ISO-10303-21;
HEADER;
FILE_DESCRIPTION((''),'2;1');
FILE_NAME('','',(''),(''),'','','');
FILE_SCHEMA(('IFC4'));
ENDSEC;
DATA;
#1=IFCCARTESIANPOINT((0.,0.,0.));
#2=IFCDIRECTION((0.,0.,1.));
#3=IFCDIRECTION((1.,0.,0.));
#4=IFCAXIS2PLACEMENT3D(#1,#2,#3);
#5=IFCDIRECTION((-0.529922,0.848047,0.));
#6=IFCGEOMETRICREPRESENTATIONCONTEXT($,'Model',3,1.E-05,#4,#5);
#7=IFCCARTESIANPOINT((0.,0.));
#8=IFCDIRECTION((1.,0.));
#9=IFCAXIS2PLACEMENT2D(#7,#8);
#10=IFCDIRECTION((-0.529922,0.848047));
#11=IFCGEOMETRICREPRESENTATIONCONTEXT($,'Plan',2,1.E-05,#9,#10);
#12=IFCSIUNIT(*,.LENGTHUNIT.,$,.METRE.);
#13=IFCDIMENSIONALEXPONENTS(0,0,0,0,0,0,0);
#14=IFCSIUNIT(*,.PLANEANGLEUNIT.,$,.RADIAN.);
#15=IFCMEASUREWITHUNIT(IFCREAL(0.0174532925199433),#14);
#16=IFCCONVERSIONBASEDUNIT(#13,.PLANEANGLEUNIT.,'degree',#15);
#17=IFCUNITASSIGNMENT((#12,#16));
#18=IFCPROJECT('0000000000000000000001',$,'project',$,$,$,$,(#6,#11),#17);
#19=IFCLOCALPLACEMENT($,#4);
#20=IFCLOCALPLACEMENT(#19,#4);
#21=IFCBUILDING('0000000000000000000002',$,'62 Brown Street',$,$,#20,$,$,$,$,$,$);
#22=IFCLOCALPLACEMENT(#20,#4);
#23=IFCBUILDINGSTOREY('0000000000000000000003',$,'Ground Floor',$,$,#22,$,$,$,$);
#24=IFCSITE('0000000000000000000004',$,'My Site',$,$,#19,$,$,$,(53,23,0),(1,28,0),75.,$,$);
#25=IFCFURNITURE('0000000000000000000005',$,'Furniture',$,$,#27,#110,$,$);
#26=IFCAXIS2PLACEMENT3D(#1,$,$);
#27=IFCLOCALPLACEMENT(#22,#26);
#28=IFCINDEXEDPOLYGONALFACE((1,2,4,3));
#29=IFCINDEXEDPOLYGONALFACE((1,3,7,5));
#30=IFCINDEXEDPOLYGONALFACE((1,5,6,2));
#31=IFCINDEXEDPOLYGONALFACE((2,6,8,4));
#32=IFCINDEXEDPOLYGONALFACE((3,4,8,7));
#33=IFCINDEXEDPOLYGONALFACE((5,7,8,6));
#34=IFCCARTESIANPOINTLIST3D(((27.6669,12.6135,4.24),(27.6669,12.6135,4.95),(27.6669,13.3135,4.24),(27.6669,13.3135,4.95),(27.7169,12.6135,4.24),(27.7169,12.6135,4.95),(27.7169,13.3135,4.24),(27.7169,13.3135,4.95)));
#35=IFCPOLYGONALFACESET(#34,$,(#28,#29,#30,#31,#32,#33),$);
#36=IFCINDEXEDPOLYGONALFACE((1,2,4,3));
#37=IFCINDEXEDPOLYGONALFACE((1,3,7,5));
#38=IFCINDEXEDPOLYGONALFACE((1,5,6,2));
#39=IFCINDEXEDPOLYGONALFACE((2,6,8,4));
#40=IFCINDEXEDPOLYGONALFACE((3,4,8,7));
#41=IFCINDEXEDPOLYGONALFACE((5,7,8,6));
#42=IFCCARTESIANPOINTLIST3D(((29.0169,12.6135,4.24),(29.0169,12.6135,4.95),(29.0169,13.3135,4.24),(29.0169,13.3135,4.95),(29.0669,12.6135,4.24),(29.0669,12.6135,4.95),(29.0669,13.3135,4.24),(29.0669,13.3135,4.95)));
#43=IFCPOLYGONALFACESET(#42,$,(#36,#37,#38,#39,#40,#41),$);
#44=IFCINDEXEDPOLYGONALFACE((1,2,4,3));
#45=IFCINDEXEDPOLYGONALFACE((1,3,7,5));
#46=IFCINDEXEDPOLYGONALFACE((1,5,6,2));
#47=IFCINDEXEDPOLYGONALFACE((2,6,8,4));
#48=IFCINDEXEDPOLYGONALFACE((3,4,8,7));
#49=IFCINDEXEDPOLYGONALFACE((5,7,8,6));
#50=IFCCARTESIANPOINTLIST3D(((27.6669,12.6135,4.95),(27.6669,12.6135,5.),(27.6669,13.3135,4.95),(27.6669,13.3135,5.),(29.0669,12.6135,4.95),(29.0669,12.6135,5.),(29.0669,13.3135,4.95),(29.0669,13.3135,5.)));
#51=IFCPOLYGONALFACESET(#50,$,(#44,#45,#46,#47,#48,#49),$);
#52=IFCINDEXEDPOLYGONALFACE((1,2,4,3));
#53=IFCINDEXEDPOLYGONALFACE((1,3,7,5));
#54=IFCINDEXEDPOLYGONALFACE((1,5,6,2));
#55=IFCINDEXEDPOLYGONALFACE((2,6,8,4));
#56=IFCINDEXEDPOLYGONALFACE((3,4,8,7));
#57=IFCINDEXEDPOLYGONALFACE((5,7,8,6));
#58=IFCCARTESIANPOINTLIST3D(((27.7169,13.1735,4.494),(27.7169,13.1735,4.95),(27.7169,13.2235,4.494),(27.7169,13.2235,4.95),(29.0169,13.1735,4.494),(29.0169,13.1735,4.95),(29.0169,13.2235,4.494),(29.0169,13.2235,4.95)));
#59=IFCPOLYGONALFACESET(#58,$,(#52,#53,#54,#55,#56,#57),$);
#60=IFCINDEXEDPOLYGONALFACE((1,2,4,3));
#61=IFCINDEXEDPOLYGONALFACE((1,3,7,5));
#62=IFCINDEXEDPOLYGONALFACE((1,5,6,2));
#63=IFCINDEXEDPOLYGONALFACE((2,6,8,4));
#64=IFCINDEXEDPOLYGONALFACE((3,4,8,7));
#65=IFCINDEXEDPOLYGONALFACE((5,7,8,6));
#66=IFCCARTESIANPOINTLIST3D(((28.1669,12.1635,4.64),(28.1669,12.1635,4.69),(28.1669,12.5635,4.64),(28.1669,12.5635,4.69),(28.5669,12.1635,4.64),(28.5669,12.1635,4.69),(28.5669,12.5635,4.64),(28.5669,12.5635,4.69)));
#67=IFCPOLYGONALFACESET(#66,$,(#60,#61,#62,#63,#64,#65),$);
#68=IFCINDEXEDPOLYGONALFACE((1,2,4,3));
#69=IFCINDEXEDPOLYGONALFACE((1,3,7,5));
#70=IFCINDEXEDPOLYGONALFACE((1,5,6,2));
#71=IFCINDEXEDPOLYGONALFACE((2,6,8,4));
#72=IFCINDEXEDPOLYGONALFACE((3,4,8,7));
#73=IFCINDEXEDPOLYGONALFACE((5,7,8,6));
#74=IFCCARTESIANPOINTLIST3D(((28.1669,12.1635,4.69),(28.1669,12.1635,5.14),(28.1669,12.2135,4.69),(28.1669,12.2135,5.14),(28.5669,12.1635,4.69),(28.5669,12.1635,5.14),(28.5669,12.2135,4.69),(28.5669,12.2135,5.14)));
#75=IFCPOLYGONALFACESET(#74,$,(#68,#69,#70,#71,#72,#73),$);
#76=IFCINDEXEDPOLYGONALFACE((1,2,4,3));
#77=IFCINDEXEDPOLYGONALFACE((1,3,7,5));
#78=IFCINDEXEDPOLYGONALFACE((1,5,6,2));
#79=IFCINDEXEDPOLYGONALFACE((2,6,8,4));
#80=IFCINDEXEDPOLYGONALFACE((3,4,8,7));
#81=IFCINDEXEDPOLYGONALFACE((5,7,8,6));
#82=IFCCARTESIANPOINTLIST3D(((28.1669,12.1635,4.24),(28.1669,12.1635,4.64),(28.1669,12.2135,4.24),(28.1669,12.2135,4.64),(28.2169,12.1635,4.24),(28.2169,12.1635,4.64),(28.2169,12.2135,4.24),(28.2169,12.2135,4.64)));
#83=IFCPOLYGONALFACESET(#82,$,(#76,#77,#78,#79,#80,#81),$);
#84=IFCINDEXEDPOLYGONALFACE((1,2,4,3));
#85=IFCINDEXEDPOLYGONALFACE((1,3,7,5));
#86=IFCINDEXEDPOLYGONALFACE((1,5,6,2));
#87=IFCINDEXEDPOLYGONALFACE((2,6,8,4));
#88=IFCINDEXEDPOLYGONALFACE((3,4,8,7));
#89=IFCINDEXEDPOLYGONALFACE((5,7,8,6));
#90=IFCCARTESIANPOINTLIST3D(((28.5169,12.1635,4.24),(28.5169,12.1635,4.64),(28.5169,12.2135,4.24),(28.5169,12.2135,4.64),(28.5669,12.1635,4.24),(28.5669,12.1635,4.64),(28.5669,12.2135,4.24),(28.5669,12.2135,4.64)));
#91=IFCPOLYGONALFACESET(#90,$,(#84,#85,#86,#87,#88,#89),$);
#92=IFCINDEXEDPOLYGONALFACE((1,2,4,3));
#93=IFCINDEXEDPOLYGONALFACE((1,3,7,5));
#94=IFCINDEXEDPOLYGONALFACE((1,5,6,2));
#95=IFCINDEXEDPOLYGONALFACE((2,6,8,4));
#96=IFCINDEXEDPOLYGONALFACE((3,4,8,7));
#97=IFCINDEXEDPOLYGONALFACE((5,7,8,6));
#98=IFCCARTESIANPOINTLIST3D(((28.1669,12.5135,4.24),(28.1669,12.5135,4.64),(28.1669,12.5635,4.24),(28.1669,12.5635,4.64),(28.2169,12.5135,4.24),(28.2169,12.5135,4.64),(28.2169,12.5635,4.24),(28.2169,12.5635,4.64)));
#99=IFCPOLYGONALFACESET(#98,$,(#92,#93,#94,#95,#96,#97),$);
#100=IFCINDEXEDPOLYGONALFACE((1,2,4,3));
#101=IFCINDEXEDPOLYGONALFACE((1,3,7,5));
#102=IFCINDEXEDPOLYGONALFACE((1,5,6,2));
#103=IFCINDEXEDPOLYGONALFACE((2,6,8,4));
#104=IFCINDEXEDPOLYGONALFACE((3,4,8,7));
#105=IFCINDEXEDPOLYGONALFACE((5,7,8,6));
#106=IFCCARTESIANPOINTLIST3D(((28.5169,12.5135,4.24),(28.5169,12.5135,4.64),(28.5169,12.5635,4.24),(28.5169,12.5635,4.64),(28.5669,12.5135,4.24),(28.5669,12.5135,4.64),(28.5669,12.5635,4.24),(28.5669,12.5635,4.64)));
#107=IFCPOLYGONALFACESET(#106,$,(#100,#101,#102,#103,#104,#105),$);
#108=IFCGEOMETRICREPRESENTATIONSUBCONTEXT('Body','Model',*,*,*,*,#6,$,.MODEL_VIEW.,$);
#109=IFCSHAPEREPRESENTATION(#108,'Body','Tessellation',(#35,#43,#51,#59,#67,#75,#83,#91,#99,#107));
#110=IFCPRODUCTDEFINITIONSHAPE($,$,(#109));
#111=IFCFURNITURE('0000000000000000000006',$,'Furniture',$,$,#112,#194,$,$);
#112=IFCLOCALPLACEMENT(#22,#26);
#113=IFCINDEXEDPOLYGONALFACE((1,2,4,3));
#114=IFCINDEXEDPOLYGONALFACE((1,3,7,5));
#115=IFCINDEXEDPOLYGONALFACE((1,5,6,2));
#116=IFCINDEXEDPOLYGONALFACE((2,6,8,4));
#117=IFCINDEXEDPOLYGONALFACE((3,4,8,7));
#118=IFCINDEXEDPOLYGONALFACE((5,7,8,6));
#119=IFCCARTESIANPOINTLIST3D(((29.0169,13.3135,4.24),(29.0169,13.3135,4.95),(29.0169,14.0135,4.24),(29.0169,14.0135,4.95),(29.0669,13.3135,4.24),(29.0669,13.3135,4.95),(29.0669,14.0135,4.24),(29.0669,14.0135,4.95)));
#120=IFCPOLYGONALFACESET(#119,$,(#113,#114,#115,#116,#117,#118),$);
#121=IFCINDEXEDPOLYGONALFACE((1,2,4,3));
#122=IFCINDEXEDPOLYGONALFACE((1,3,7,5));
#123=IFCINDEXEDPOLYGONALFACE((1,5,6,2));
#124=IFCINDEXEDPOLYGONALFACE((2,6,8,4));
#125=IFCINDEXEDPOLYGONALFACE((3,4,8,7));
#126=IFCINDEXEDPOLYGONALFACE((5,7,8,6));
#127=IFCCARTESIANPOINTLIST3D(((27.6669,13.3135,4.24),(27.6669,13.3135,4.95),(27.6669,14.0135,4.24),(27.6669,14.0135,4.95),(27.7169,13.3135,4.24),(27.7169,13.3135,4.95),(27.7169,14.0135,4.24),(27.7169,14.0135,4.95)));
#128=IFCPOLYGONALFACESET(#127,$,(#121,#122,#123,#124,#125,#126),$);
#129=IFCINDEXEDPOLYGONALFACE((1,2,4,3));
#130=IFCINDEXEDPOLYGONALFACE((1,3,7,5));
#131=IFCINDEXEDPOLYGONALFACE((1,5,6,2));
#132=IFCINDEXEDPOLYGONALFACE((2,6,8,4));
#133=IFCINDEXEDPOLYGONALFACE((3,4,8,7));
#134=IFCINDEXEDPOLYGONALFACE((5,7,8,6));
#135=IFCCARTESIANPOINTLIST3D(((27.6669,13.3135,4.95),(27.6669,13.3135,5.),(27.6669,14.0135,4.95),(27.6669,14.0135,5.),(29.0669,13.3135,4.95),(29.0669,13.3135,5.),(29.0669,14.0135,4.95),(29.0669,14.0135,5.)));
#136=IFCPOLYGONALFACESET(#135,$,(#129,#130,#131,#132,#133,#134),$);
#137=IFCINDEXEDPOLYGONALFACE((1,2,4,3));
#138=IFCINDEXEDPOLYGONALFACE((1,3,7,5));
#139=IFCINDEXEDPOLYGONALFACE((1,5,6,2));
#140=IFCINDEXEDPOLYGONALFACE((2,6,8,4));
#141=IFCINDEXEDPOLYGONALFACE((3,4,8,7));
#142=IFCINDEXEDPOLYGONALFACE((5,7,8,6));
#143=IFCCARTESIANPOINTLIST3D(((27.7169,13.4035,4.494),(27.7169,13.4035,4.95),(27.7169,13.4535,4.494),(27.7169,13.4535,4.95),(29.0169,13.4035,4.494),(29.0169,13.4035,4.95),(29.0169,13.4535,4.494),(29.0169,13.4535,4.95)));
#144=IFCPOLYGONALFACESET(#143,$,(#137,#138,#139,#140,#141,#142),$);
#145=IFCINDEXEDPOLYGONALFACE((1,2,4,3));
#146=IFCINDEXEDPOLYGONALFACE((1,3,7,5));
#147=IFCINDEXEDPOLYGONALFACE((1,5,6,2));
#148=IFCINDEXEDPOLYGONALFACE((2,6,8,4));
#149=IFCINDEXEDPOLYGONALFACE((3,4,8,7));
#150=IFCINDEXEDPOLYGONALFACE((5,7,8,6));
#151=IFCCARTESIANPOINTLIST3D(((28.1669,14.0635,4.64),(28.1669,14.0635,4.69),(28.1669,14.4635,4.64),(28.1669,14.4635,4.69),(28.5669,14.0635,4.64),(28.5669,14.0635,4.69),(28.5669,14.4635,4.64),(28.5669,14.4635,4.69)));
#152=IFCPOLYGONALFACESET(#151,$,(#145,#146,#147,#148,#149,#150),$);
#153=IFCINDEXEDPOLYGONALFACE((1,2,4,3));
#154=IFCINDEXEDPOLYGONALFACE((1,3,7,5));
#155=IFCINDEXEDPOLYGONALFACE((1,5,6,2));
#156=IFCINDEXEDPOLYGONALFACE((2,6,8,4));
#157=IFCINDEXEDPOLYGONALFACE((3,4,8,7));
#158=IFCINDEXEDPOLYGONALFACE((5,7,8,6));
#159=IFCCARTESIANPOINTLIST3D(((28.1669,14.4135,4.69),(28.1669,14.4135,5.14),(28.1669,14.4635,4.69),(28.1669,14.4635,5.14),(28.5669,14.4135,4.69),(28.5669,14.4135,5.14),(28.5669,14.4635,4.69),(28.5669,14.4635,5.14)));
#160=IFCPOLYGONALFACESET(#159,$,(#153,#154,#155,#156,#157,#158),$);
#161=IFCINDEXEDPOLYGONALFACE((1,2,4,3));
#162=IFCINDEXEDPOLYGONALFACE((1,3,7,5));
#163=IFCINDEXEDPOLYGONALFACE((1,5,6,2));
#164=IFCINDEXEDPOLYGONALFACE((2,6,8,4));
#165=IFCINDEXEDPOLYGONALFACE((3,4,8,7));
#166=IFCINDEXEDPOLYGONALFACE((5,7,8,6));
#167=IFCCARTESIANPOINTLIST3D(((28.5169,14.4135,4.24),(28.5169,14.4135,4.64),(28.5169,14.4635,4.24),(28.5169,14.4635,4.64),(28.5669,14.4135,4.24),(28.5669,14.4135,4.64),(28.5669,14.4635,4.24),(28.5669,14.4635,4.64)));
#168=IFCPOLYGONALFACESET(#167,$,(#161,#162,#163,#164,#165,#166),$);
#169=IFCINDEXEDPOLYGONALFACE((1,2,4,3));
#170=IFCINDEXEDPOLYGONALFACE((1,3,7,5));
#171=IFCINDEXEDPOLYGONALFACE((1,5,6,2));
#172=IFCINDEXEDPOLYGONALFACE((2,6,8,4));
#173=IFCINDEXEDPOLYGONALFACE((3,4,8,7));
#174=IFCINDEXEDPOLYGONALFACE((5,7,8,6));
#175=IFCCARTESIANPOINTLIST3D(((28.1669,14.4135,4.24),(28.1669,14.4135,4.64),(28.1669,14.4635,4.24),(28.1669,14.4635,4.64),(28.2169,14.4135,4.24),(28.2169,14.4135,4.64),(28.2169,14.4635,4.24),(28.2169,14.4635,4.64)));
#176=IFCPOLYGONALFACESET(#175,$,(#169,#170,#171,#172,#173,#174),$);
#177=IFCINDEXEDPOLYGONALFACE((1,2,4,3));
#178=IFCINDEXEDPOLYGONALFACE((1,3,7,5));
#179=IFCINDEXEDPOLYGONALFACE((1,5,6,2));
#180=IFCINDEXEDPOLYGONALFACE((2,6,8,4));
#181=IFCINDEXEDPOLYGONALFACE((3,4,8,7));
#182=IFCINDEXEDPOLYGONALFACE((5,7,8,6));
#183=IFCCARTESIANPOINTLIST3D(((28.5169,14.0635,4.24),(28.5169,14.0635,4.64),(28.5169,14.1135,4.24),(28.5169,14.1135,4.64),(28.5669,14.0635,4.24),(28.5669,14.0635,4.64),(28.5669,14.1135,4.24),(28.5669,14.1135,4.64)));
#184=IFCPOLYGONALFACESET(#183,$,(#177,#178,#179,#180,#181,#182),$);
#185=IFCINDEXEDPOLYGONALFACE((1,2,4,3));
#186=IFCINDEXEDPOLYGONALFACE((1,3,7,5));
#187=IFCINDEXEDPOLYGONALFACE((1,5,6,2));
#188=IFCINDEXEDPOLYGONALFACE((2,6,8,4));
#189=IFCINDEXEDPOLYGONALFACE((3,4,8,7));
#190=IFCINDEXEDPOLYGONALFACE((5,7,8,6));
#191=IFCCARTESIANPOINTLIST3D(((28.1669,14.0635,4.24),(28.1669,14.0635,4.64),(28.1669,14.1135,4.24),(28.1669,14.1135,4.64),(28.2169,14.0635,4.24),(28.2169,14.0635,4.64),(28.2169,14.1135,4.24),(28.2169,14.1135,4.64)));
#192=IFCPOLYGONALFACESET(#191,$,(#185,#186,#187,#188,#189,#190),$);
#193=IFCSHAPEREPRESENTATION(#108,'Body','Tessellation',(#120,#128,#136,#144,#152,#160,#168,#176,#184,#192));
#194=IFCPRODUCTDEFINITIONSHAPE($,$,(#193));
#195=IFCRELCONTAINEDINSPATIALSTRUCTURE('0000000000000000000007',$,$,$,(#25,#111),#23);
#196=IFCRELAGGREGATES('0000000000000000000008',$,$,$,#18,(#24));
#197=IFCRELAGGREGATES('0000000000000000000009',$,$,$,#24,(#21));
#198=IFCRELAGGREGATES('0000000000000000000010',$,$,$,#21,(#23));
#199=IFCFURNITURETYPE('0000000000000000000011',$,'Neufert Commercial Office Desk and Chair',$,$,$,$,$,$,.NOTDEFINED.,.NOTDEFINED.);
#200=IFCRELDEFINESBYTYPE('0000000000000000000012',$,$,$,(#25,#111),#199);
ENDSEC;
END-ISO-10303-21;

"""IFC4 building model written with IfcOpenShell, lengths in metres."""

from ifc_helpers import new_model, entity, si_unit, converted_unit, direction, frame, origin_with_axes, origin_2d_with_axis, place, context, subcontext, project, spatial, line, indexed_curve, outline, extrude, shape, source, transform, mapped, type_object, type_shapes, element, save


model = new_model("IFC4")

# Units and contexts
model_context = context("Model", 3, precision=1e-05, world=origin_with_axes(), true_north=direction((-0.529922, 0.848047, 0.0)))
plan_context = context("Plan", 2, precision=1e-05, world=origin_2d_with_axis(), true_north=direction((-0.529922, 0.848047)))
body_context_1 = subcontext(model_context, "Body", "Model", "MODEL_VIEW")
body_context_2 = subcontext(plan_context, "Body", "Plan", "PLAN_VIEW")
ifc_project = project(units=[si_unit("LENGTHUNIT", "METRE"), converted_unit("PLANEANGLEUNIT", "degree", entity("IfcReal", 0.0174532925199433), si_unit("PLANEANGLEUNIT", "RADIAN"), dimensions=[0, 0, 0, 0, 0, 0, 0])], contexts=[model_context, plan_context])

# Site, building, storey
site_placement = place(None, origin_with_axes())
site = spatial("IfcSite", under=ifc_project, at=site_placement, Name="My Site", RefLatitude=(53, 23, 0), RefLongitude=(1, 28, 0), RefElevation=75.0)
building_placement = place(site_placement, origin_with_axes())
building = spatial("IfcBuilding", under=site, at=building_placement, Name="62 Brown Street")
storey_placement = place(building_placement, origin_with_axes())
storey = spatial("IfcBuildingStorey", under=building, at=storey_placement, Name="Ground Floor")

# Furniture
furniture_type_1 = type_object("IfcFurnitureType", Name="Neufert Commercial Office Desk and Chair", AssemblyPlace="NOTDEFINED", PredefinedType="NOTDEFINED")
shared_shape_1 = source(origin_with_axes(), body_context_1, "Body", "SweptSolid", [
    extrude(outline(indexed_curve([(0.0, 0.0), (0.05, 0.0), (0.05, 0.7), (0.0, 0.7)], segments=[line(1, 2, 3, 4, 1)])), frame((0.0, 0.45, 0.0), z_axis=(0.0, 0.0, 1.0), x_axis=(1.0, 0.0, 0.0)), (0.0, 0.0, 1.0), 0.71),
    extrude(outline(indexed_curve([(0.0, 0.0), (0.05, 0.0), (0.05, 0.7), (0.0, 0.7)], segments=[line(1, 2, 3, 4, 1)])), frame((1.35, 0.45, 0.0), z_axis=(0.0, 0.0, 1.0), x_axis=(1.0, 0.0, 0.0)), (0.0, 0.0, 1.0), 0.71),
    extrude(outline(indexed_curve([(0.0, 0.0), (1.4, 0.0), (1.4, 0.7), (0.0, 0.7)], segments=[line(1, 2, 3, 4, 1)])), frame((0.0, 0.45, 0.71), z_axis=(0.0, 0.0, 1.0), x_axis=(1.0, 0.0, 0.0)), (0.0, 0.0, 1.0), 0.05),
    extrude(outline(indexed_curve([(0.05, 0.56), (1.35, 0.56), (1.35, 0.61), (0.05, 0.61)], segments=[line(1, 2, 3, 4, 1)])), frame((0.0, 0.45, 0.254), z_axis=(0.0, 0.0, 1.0), x_axis=(1.0, 0.0, 0.0)), (0.0, 0.0, 1.0), 0.456),
    extrude(outline(indexed_curve([(-0.2, 0.0), (0.2, 0.0), (0.2, 0.4), (-0.2, 0.4)], segments=[line(1, 2, 3, 4, 1)])), frame((0.7, 0.0, 0.45), z_axis=(0.0, 0.0, 1.0), x_axis=(1.0, 0.0, 0.0)), (0.0, 0.0, -1.0), 0.05),
    extrude(outline(indexed_curve([(-0.2, 0.0), (0.2, 0.0), (0.2, 0.05), (-0.2, 0.05)], segments=[line(1, 2, 3, 4, 1)])), frame((0.7, 0.0, 0.9), z_axis=(0.0, 0.0, 1.0), x_axis=(1.0, 0.0, 0.0)), (0.0, 0.0, -1.0), 0.45),
    extrude(outline(indexed_curve([(-0.2, 0.0), (-0.15, 0.0), (-0.15, 0.05), (-0.2, 0.05)], segments=[line(1, 2, 3, 4, 1)])), frame((0.7, 0.0, 0.0), z_axis=(0.0, 0.0, 1.0), x_axis=(1.0, 0.0, 0.0)), (0.0, 0.0, 1.0), 0.4),
    extrude(outline(indexed_curve([(0.2, 0.0), (0.15, 0.0), (0.15, 0.05), (0.2, 0.05)], segments=[line(1, 2, 3, 4, 1)])), frame((0.7, 0.0, 0.0), z_axis=(0.0, 0.0, 1.0), x_axis=(1.0, 0.0, 0.0)), (0.0, 0.0, 1.0), 0.4),
    extrude(outline(indexed_curve([(-0.2, 0.4), (-0.15, 0.4), (-0.15, 0.35), (-0.2, 0.35)], segments=[line(1, 2, 3, 4, 1)])), frame((0.7, 0.0, 0.0), z_axis=(0.0, 0.0, 1.0), x_axis=(1.0, 0.0, 0.0)), (0.0, 0.0, 1.0), 0.4),
    extrude(outline(indexed_curve([(0.2, 0.4), (0.15, 0.4), (0.15, 0.35), (0.2, 0.35)], segments=[line(1, 2, 3, 4, 1)])), frame((0.7, 0.0, 0.0), z_axis=(0.0, 0.0, 1.0), x_axis=(1.0, 0.0, 0.0)), (0.0, 0.0, 1.0), 0.4),
])
shared_shape_2 = source(origin_with_axes(), body_context_2, "Body", "Curve2D", [
    entity("IfcIndexedPolyCurve", entity("IfcCartesianPointList2D", [[0.0, 0.45], [1.4, 0.45], [1.4, 1.15], [0.0, 1.15]]), [entity("IfcLineIndex", [1, 2, 3, 4, 1])]),
    entity("IfcIndexedPolyCurve", entity("IfcCartesianPointList2D", [[0.5, 0.4], [0.9, 0.4]])),
    entity("IfcIndexedPolyCurve", entity("IfcCartesianPointList2D", [[0.5, 0.4], [0.5, 0.2], [0.5586, 0.0586], [0.7, 0.0], [0.8414, 0.0586], [0.9, 0.2], [0.9, 0.4]]), [entity("IfcLineIndex", [1, 2]), entity("IfcArcIndex", [2, 3, 4]), entity("IfcArcIndex", [4, 5, 6]), entity("IfcLineIndex", [6, 7])]),
    entity("IfcIndexedPolyCurve", entity("IfcCartesianPointList2D", [[0.54, 0.4], [0.54, 0.2], [0.5869, 0.0869], [0.7, 0.04], [0.8131, 0.0869], [0.86, 0.2], [0.86, 0.4]]), [entity("IfcLineIndex", [1, 2]), entity("IfcArcIndex", [2, 3, 4]), entity("IfcArcIndex", [4, 5, 6]), entity("IfcLineIndex", [6, 7])]),
])
type_shapes(furniture_type_1, [shared_shape_1, shared_shape_2])
for number, where, z_axis, x_axis, name in (
    (1, (27.6669, 12.1635, 4.24), (0.0, 0.0, 1.0), (1.0, 0.0, 0.0), "Furniture"),
    (2, (29.0669, 14.4635, 4.24), (0.0, 0.0, 1.0), (-1.0, 0.0, 0.0), "Furniture"),
):
    element("IfcFurniture", number, at=place(storey_placement, frame(where, z_axis=z_axis, x_axis=x_axis)), inside=storey, type_object=furniture_type_1, Name=name, shapes=[
        shape(body_context_1, "Body", "MappedRepresentation", [mapped(shared_shape_1, transform((0.0, 0.0, 0.0), x_axis=(1.0, 0.0, 0.0), y_axis=(0.0, 1.0, 0.0), z_axis=(0.0, 0.0, 1.0), scale=1.0))]),
        shape(body_context_2, "Body", "MappedRepresentation", [mapped(shared_shape_2, transform((0.0, 0.0, 0.0), x_axis=(1.0, 0.0, 0.0), y_axis=(0.0, 1.0, 0.0), z_axis=(0.0, 0.0, 1.0), scale=1.0))]),
    ])

save(model, "model.ifc")
